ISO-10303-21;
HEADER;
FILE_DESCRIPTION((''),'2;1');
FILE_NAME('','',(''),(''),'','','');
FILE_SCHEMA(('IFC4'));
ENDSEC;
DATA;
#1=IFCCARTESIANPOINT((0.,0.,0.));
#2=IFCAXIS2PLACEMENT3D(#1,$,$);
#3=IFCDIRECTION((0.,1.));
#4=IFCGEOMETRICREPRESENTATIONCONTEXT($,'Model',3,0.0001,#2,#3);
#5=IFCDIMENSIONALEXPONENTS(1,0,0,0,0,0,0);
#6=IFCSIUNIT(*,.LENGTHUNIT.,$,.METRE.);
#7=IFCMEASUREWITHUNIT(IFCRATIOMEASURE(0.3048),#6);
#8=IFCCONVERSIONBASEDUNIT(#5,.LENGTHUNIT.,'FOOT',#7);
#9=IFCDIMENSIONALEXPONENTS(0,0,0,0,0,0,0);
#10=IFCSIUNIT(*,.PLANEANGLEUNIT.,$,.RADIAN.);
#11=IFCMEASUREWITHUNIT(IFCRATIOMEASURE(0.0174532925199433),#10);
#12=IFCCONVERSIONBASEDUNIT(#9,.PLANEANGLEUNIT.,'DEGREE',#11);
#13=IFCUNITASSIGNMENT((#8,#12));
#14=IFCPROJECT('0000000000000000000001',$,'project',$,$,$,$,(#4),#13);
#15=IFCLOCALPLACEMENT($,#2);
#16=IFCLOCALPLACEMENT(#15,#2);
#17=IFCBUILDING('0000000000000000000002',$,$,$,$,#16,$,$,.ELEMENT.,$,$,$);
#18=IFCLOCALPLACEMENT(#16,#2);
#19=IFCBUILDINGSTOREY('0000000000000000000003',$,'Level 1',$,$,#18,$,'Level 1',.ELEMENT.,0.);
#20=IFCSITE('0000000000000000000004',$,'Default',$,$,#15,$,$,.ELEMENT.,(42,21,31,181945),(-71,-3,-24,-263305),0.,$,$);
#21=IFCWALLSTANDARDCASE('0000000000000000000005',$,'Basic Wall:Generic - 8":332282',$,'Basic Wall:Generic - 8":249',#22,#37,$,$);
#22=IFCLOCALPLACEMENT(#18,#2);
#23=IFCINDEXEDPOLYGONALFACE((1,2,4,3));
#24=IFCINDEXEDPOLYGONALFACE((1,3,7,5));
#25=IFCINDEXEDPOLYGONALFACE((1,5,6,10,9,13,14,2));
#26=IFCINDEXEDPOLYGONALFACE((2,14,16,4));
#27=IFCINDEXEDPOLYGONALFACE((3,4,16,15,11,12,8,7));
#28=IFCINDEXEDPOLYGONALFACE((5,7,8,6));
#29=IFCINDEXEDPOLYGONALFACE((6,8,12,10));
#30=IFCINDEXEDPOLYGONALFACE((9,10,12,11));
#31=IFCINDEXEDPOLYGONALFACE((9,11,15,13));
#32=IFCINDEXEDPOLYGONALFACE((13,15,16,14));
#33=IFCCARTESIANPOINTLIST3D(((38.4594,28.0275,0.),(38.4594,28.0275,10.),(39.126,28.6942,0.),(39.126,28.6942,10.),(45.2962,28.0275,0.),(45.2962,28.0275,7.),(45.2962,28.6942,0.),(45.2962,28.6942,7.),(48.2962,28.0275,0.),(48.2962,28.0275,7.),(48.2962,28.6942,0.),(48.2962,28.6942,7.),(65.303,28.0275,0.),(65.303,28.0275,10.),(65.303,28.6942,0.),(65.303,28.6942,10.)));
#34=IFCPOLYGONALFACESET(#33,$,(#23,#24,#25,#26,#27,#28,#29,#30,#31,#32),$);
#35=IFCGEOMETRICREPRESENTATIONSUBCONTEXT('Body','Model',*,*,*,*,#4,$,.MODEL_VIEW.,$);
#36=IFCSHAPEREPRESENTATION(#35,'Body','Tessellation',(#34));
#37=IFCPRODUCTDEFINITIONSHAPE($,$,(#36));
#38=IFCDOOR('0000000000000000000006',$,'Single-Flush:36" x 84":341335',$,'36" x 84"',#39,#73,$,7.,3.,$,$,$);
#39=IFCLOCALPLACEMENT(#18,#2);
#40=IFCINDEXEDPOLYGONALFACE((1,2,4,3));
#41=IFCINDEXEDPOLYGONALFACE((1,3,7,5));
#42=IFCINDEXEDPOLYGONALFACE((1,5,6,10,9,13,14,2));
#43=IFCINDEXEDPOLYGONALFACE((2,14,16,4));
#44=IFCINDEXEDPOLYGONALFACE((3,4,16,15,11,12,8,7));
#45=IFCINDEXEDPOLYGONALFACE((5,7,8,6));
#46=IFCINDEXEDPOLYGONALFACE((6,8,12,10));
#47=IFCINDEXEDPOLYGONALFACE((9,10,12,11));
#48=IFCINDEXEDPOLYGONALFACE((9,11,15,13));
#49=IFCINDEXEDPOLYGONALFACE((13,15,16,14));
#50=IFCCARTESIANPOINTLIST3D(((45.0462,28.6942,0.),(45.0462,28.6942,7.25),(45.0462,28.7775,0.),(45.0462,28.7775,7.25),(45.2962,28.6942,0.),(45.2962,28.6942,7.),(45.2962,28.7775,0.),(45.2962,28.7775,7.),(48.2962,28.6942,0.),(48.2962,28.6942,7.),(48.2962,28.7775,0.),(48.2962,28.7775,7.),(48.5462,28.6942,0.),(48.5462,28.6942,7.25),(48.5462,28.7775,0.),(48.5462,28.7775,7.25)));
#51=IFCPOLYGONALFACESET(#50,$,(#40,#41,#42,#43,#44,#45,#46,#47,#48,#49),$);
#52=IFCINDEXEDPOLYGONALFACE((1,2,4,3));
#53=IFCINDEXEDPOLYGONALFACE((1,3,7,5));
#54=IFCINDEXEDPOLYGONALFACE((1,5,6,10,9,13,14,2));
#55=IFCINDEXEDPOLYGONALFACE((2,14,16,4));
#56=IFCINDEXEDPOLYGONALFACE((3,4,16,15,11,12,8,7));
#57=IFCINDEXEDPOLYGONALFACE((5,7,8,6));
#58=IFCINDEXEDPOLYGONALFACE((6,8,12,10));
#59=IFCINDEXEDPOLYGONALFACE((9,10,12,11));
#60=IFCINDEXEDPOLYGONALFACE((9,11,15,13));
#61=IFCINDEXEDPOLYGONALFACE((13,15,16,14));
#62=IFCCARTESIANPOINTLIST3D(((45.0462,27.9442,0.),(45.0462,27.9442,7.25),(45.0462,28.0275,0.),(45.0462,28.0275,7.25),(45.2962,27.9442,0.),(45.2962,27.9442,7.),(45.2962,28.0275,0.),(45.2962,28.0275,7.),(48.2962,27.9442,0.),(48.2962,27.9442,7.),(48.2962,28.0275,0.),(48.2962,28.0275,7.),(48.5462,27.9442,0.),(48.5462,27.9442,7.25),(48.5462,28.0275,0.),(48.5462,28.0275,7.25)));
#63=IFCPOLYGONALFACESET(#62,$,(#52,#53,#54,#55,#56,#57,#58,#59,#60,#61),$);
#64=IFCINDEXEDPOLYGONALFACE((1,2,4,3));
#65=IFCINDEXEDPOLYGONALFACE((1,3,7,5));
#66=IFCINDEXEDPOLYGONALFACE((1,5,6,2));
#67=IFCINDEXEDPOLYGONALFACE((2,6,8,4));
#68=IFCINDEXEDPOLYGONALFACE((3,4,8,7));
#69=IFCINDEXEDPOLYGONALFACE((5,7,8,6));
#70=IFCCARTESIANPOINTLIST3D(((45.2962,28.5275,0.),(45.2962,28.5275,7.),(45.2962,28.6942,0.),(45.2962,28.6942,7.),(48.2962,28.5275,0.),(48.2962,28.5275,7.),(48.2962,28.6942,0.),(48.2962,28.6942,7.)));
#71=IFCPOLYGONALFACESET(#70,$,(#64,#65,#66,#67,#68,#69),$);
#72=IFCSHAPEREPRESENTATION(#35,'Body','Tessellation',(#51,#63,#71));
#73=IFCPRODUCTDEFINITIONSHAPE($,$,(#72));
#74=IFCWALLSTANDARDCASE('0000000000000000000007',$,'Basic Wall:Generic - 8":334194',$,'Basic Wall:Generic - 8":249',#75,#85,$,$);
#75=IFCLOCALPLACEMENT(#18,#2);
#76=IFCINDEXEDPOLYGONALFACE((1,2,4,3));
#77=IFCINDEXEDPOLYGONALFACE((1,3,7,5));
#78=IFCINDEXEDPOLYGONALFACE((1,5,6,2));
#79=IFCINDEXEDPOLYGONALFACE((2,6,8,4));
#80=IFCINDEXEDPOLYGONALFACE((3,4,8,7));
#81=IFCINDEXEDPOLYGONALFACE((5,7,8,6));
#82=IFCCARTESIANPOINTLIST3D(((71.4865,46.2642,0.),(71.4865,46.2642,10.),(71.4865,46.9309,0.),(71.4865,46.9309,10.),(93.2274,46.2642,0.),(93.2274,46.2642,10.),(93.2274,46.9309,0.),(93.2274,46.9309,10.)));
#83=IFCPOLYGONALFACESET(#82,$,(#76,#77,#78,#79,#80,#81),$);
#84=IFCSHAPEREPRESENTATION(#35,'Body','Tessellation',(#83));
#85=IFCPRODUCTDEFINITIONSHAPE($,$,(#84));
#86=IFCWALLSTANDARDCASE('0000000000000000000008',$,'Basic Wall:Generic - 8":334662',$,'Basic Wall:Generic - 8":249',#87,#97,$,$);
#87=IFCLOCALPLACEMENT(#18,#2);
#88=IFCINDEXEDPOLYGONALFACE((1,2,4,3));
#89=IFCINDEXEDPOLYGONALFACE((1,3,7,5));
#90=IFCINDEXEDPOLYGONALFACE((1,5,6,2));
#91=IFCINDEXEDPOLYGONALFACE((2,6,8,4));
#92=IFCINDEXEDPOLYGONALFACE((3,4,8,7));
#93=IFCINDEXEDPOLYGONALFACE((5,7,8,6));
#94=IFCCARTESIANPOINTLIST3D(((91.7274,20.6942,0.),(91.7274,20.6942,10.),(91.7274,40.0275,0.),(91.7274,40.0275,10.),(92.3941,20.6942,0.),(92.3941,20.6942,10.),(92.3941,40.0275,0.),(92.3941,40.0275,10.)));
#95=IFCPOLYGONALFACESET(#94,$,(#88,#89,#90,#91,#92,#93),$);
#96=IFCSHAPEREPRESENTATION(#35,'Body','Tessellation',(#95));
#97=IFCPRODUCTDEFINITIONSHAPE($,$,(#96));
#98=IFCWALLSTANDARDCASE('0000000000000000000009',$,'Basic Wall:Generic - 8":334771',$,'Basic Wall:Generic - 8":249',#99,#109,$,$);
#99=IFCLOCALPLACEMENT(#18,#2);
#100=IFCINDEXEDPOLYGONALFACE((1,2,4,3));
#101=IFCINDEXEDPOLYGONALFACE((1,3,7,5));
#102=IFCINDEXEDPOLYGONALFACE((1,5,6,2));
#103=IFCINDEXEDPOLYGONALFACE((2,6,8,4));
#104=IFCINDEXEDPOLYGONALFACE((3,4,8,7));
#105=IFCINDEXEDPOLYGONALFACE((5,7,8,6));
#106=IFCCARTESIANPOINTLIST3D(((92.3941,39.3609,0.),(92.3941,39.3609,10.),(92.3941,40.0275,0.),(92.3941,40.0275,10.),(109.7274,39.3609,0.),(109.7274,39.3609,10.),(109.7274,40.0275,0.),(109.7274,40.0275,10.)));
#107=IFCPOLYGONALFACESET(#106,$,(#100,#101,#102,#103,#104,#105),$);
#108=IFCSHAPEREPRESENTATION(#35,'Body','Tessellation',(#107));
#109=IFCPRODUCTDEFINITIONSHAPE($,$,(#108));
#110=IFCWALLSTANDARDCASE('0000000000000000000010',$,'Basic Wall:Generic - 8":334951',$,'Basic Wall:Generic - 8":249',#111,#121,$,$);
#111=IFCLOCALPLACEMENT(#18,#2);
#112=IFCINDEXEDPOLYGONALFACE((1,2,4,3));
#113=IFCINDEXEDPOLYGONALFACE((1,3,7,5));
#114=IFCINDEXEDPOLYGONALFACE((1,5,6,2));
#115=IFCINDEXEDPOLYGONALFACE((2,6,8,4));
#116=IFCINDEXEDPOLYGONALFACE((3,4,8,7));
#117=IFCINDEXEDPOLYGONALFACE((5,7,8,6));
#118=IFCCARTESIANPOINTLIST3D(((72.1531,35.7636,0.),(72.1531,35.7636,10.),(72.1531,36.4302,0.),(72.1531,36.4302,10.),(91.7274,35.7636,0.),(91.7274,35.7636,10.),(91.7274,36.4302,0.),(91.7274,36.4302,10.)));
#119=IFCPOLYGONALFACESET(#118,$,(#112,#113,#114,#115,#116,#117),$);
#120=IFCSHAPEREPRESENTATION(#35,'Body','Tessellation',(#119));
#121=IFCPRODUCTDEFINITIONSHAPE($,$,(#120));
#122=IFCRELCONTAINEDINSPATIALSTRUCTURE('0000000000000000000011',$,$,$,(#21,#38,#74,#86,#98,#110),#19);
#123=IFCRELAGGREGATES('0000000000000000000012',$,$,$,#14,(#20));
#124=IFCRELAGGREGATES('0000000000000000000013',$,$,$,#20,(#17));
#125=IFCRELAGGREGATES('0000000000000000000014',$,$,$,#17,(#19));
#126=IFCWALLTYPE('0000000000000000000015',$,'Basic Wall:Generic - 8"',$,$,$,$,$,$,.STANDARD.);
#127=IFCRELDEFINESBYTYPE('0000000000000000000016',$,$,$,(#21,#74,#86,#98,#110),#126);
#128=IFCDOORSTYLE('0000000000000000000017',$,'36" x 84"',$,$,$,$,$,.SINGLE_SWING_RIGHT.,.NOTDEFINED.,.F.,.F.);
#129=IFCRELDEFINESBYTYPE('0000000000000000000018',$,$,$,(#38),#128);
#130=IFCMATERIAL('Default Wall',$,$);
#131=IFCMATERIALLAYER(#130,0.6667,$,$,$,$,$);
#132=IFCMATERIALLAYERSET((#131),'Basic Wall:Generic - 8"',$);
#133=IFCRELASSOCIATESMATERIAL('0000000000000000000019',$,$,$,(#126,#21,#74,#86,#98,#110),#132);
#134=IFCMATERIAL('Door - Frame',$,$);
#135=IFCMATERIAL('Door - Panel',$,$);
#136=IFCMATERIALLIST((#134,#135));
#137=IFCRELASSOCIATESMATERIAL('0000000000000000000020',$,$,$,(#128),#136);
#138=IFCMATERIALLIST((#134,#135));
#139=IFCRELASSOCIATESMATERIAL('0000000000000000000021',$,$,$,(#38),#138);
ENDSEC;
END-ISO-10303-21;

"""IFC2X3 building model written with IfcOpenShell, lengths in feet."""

from ifc_helpers import new_model, entity, si_unit, converted_unit, direction, frame, frame_2d, origin, place, context, subcontext, project, spatial, polyline, rectangle, outline, extrude, source, transform, mapped, material, material_list, layer, layer_set, layer_usage, type_object, type_shapes, element, fill, save


model = new_model("IFC2X3")

# Units and contexts
model_context = context("Model", 3, precision=0.0001, world=origin(), true_north=direction((0.0, 1.0)))
body_context = subcontext(model_context, "Body", "Model", "MODEL_VIEW")
ifc_project = project(units=[converted_unit("LENGTHUNIT", "FOOT", entity("IfcRatioMeasure", 0.3048), si_unit("LENGTHUNIT", "METRE"), dimensions=[1, 0, 0, 0, 0, 0, 0]), converted_unit("PLANEANGLEUNIT", "DEGREE", entity("IfcRatioMeasure", 0.0174532925199433), si_unit("PLANEANGLEUNIT", "RADIAN"), dimensions=[0, 0, 0, 0, 0, 0, 0])], contexts=[model_context])

# Site, building, storey
site_placement = place(None, origin())
site = spatial("IfcSite", under=ifc_project, at=site_placement, Name="Default", CompositionType="ELEMENT", RefLatitude=(42, 21, 31, 181945), RefLongitude=(-71, -3, -24, -263305), RefElevation=0.0)
building_placement = place(site_placement, origin())
building = spatial("IfcBuilding", under=site, at=building_placement, CompositionType="ELEMENT")
storey_placement = place(building_placement, origin())
storey = spatial("IfcBuildingStorey", under=building, at=storey_placement, Name="Level 1", LongName="Level 1", CompositionType="ELEMENT", Elevation=0.0)

# Shared definitions
ifc_material_1 = material(Name="Default Wall")
ifc_layer = layer(ifc_material_1, 0.6667)
ifc_layer_set = layer_set([ifc_layer], Name="Basic Wall:Generic - 8\"")
wall_type = type_object("IfcWallType", Name="Basic Wall:Generic - 8\"", PredefinedType="STANDARD", material=ifc_layer_set)
ifc_material_2 = material(Name="Door - Frame")
ifc_material_3 = material(Name="Door - Panel")
ifc_material_list_1 = material_list([ifc_material_2, ifc_material_3])
door_style = type_object("IfcDoorStyle", Name="36\" x 84\"", ConstructionType="NOTDEFINED", OperationType="SINGLE_SWING_RIGHT", ParameterTakesPrecedence=False, Sizeable=False, material=ifc_material_list_1)
shared_shape = source(origin(), body_context, "Body", "SweptSolid", [
    extrude(outline(polyline([(-1.75, -3.6875), (1.75, -3.6875), (1.75, 3.5625), (1.5, 3.5625), (1.5, -3.4375), (-1.5, -3.4375), (-1.5, 3.5625), (-1.75, 3.5625), (-1.75, -3.6875)])), frame((1.5, 0.6667, 3.5625), z_axis=(0.0, 1.0, 0.0), x_axis=(1.0, 0.0, 0.0)), (0.0, 0.0, 1.0), 0.0833),
    extrude(outline(polyline([(-3.6875, -1.75), (3.5625, -1.75), (3.5625, -1.5), (-3.4375, -1.5), (-3.4375, 1.5), (3.5625, 1.5), (3.5625, 1.75), (-3.6875, 1.75), (-3.6875, -1.75)])), frame((1.5, -0.0833, 3.5625), z_axis=(0.0, 1.0, 0.0), x_axis=(0.0, 0.0, -1.0)), (0.0, 0.0, 1.0), 0.0833),
    extrude(rectangle(XDim=0.1667, YDim=3.0, at=frame_2d((0.0, 0.0), x_axis=(1.0, 0.0))), frame((1.5, 0.5833, 0.0), z_axis=(0.0, 0.0, 1.0), x_axis=(0.0, 1.0, 0.0)), (0.0, 0.0, 1.0), 7.0),
])
type_shapes(door_style, [shared_shape])

# Wall, opening, door
ifc_layer_usage_1 = layer_usage(ifc_layer_set, "AXIS2", "NEGATIVE", 0.3333)
wall_1_placement = place(storey_placement, frame((65.303, 28.3609, 0.0), z_axis=(0.0, 0.0, 1.0), x_axis=(-1.0, 0.0, 0.0)))
wall_1 = element("IfcWallStandardCase", 1, at=wall_1_placement, inside=storey, type_object=wall_type, material=ifc_layer_usage_1, Name="Basic Wall:Generic - 8\":332282", ObjectType="Basic Wall:Generic - 8\":249", context=body_context, shape_type="SweptSolid", body=[
    extrude(outline(polyline([(0.0, -0.3333), (15.1735, -0.3333), (15.8401, -0.3333), (25.9321, -0.3333), (26.177, -0.3333), (26.552, 0.0417), (26.8436, 0.3333), (25.9008, 0.3333), (0.0, 0.3333), (0.0, -0.3333)])), origin(), (0.0, 0.0, 1.0), 10.0),
])
opening_1_placement = place(wall_1_placement, frame((20.0068, 0.3333, 0.0)))
opening_1 = element("IfcOpeningElement", 2, at=opening_1_placement, cuts=wall_1, ObjectType="Opening", context=body_context, shape_type="SweptSolid", body=[
    extrude(rectangle(XDim=3.0, YDim=7.0, at=frame_2d((3.5, 1.5), x_axis=(0.0, 1.0))), frame((0.0, 0.0, 0.0), z_axis=(0.0, -1.0, 0.0), x_axis=(0.0, 0.0, 1.0)), (0.0, 0.0, 1.0), 0.6667),
])
ifc_material_list_2 = material_list([ifc_material_2, ifc_material_3])
door_1_placement = place(opening_1_placement, frame((0.0, 0.0, 0.0), z_axis=(0.0, 0.0, 1.0), x_axis=(-1.0, 0.0, 0.0)))
door_1 = element("IfcDoor", 3, at=door_1_placement, inside=storey, type_object=door_style, material=ifc_material_list_2, Name="Single-Flush:36\" x 84\":341335", ObjectType="36\" x 84\"", OverallHeight=7.0, OverallWidth=3.0, context=body_context, shape_type="MappedRepresentation", body=[
    mapped(shared_shape, transform((0.0, 0.0, 0.0), scale=1.0)),
])
fill(opening_1, door_1)

# Wall
ifc_layer_usage_2 = layer_usage(ifc_layer_set, "AXIS2", "NEGATIVE", 0.3333)
wall_2_placement = place(storey_placement, frame((71.4865, 46.5976, 0.0)))
element("IfcWallStandardCase", 4, at=wall_2_placement, inside=storey, type_object=wall_type, material=ifc_layer_usage_2, Name="Basic Wall:Generic - 8\":334194", ObjectType="Basic Wall:Generic - 8\":249", context=body_context, shape_type="SweptSolid", body=[
    extrude(rectangle(XDim=21.741, YDim=0.6667, at=frame_2d((10.8705, 0.0), x_axis=(-1.0, 0.0))), origin(), (0.0, 0.0, 1.0), 10.0),
])

# Walls
ifc_layer_usage_3 = layer_usage(ifc_layer_set, "AXIS2", "NEGATIVE", 0.3333)
wall_3_placement = place(storey_placement, frame((92.0608, 20.6942, 0.0), z_axis=(0.0, 0.0, 1.0), x_axis=(0.0, 1.0, 0.0)))
element("IfcWallStandardCase", 5, at=wall_3_placement, inside=storey, type_object=wall_type, material=ifc_layer_usage_3, Name="Basic Wall:Generic - 8\":334662", ObjectType="Basic Wall:Generic - 8\":249", context=body_context, shape_type="SweptSolid", body=[
    extrude(rectangle(XDim=19.3333, YDim=0.6667, at=frame_2d((9.6667, 0.0), x_axis=(-1.0, 0.0))), origin(), (0.0, 0.0, 1.0), 10.0),
])
ifc_layer_usage_4 = layer_usage(ifc_layer_set, "AXIS2", "NEGATIVE", 0.3333)
wall_4_placement = place(storey_placement, frame((92.3941, 39.6942, 0.0)))
element("IfcWallStandardCase", 6, at=wall_4_placement, inside=storey, type_object=wall_type, material=ifc_layer_usage_4, Name="Basic Wall:Generic - 8\":334771", ObjectType="Basic Wall:Generic - 8\":249", context=body_context, shape_type="SweptSolid", body=[
    extrude(rectangle(XDim=17.3333, YDim=0.6667, at=frame_2d((8.6667, 0.0), x_axis=(-1.0, 0.0))), origin(), (0.0, 0.0, 1.0), 10.0),
])
ifc_layer_usage_5 = layer_usage(ifc_layer_set, "AXIS2", "NEGATIVE", 0.3333)
wall_5_placement = place(storey_placement, frame((91.7274, 36.0969, 0.0), z_axis=(0.0, 0.0, 1.0), x_axis=(-1.0, 0.0, 0.0)))
element("IfcWallStandardCase", 7, at=wall_5_placement, inside=storey, type_object=wall_type, material=ifc_layer_usage_5, Name="Basic Wall:Generic - 8\":334951", ObjectType="Basic Wall:Generic - 8\":249", context=body_context, shape_type="SweptSolid", body=[
    extrude(rectangle(XDim=19.5743, YDim=0.6667, at=frame_2d((9.7871, 0.0), x_axis=(-1.0, 0.0))), origin(), (0.0, 0.0, 1.0), 10.0),
])

save(model, "model.ifc")
